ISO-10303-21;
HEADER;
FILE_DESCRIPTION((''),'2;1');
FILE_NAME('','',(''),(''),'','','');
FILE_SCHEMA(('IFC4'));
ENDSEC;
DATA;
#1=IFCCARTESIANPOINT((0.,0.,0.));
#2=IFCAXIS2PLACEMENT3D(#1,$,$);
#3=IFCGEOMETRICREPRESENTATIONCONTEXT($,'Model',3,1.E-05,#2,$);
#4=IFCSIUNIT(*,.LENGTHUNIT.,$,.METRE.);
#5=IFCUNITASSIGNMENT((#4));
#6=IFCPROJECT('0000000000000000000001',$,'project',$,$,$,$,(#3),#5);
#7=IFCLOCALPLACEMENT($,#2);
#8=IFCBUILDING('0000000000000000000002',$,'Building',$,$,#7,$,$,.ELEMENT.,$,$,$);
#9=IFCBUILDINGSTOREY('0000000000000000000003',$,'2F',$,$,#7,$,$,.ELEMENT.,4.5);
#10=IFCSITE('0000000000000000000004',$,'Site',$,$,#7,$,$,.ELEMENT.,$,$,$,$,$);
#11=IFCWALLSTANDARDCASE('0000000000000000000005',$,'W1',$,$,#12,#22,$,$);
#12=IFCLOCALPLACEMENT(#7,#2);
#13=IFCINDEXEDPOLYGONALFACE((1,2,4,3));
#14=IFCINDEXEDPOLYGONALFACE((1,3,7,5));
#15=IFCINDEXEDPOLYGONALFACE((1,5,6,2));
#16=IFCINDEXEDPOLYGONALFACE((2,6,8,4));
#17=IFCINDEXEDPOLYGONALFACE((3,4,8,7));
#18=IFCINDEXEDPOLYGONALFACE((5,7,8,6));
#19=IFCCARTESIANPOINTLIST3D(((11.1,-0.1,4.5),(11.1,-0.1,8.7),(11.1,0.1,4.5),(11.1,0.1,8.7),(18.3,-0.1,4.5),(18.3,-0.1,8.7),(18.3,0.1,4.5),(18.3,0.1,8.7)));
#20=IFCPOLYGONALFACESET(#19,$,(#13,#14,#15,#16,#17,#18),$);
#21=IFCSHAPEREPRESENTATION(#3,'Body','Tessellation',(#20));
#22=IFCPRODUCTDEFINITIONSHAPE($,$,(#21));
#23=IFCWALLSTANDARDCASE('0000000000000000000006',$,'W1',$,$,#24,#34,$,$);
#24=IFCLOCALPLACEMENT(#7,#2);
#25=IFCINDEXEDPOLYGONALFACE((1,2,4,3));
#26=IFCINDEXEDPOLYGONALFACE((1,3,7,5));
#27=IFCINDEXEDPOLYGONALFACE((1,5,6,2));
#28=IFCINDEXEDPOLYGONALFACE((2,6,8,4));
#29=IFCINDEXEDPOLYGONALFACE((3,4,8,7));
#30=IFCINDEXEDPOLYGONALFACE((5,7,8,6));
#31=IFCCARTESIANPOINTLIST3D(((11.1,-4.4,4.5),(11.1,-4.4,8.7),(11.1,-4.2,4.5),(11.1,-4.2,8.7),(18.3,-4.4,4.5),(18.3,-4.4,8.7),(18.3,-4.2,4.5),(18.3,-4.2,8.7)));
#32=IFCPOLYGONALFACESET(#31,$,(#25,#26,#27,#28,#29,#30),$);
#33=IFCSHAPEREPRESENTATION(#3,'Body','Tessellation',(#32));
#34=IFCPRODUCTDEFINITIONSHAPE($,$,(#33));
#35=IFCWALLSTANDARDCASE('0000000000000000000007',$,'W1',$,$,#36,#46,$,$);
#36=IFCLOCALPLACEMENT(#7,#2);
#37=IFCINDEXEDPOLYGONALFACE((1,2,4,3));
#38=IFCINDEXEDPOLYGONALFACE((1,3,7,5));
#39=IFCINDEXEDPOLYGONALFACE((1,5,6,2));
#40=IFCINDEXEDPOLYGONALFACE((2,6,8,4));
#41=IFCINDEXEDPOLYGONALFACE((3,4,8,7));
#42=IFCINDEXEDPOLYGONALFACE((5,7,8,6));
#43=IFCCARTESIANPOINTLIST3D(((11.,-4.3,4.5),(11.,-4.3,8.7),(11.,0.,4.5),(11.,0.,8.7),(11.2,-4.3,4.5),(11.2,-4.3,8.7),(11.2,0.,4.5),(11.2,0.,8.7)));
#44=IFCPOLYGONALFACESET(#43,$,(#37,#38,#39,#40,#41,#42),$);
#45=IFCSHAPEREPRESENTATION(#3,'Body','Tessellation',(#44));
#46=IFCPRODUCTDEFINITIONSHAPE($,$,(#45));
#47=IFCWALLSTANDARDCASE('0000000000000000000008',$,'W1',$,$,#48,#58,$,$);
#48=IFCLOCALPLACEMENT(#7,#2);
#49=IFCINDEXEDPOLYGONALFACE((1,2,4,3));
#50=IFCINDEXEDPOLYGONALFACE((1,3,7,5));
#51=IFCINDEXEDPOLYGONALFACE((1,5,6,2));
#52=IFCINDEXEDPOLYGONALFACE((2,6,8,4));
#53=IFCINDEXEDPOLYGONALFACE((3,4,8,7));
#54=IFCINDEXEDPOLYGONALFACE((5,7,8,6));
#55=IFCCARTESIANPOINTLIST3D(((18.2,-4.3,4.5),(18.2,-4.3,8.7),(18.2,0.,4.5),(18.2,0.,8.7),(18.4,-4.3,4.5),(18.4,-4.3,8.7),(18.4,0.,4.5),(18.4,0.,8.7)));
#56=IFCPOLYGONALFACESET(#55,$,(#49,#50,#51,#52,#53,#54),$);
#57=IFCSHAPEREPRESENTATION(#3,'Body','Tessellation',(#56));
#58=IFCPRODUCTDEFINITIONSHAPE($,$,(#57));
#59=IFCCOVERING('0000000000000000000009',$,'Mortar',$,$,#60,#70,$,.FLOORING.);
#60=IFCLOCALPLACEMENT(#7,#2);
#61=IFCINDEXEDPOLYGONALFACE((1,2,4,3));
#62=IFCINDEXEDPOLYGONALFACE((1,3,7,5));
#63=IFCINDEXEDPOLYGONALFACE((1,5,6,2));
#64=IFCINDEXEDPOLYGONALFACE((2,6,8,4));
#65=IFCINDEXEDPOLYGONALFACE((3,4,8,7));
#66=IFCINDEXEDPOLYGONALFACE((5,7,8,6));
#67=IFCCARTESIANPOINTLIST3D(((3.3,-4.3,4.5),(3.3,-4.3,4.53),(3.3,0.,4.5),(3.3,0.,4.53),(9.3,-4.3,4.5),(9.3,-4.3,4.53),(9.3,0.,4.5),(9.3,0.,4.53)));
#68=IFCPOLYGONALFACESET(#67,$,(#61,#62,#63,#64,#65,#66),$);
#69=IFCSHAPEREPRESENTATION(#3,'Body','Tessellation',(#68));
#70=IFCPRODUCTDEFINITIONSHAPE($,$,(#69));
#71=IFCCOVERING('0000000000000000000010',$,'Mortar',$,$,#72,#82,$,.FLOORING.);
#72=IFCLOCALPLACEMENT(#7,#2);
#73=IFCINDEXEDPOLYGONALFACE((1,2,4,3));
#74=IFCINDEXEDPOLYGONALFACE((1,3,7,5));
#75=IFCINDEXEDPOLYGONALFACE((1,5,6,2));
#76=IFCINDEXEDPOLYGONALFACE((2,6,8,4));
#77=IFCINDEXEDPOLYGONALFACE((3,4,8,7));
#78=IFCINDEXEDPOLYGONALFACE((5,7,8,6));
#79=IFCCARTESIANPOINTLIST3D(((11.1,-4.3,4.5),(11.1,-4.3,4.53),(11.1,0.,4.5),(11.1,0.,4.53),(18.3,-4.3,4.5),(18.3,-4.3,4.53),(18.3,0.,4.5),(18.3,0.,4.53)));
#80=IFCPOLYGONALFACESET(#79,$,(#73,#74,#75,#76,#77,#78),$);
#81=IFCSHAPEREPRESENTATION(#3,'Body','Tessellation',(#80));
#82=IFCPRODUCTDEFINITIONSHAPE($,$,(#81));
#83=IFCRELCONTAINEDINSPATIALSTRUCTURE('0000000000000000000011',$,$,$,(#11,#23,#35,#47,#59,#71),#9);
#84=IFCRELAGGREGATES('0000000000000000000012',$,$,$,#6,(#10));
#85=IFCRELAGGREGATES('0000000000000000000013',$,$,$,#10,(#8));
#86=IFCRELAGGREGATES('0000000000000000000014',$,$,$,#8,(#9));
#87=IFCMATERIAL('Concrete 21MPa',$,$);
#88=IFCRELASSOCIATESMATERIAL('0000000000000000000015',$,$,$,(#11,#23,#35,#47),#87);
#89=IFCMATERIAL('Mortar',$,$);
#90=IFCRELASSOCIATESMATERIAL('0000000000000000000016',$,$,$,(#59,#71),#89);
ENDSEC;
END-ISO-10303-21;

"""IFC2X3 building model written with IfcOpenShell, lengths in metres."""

from ifc_helpers import new_model, si_unit, frame, origin, origin_2d, place, context, project, spatial, rectangle, extrude, material, element, save


model = new_model("IFC2X3")

# Units and contexts
model_context = context("Model", 3, precision=1e-05, world=origin())
ifc_project = project(units=[si_unit("LENGTHUNIT", "METRE")], contexts=[model_context])

# Site, building, storey
placement = place(None, origin())
site = spatial("IfcSite", under=ifc_project, at=placement, Name="Site", CompositionType="ELEMENT")
building = spatial("IfcBuilding", under=site, at=placement, Name="Building", CompositionType="ELEMENT")
storey = spatial("IfcBuildingStorey", under=building, at=placement, Name="2F", CompositionType="ELEMENT", Elevation=4.5)

# Shared definitions
ifc_material_1 = material(Name="Concrete 21MPa")

# Walls
for number, where, name in (
    (1, (14.7, 0.0, 4.5), "W1"),
    (2, (14.7, -4.3, 4.5), "W1"),
):
    element("IfcWallStandardCase", number, at=place(None, frame(where)), inside=storey, material=ifc_material_1, Name=name, context=model_context, shape_type="SweptSolid", body=[
        extrude(rectangle(XDim=7.2, YDim=0.2, at=origin_2d()), origin(), (0.0, 0.0, 1.0), 4.2),
    ])
for number, where, name in (
    (3, (11.1, -2.15, 4.5), "W1"),
    (4, (18.3, -2.15, 4.5), "W1"),
):
    element("IfcWallStandardCase", number, at=place(None, frame(where)), inside=storey, material=ifc_material_1, Name=name, context=model_context, shape_type="SweptSolid", body=[
        extrude(rectangle(XDim=0.2, YDim=4.3, at=origin_2d()), origin(), (0.0, 0.0, 1.0), 4.2),
    ])

# Coverings
ifc_material_2 = material(Name="Mortar")
covering_1_placement = place(None, frame((6.3, -2.15, 4.5)))
element("IfcCovering", 5, at=covering_1_placement, inside=storey, material=ifc_material_2, Name="Mortar", PredefinedType="FLOORING", context=model_context, shape_type="SweptSolid", body=[
    extrude(rectangle(XDim=6.0, YDim=4.3, at=origin_2d()), origin(), (0.0, 0.0, 1.0), 0.03),
])
covering_2_placement = place(None, frame((14.7, -2.15, 4.5)))
element("IfcCovering", 6, at=covering_2_placement, inside=storey, material=ifc_material_2, Name="Mortar", PredefinedType="FLOORING", context=model_context, shape_type="SweptSolid", body=[
    extrude(rectangle(XDim=7.2, YDim=4.3, at=origin_2d()), origin(), (0.0, 0.0, 1.0), 0.03),
])

save(model, "model.ifc")
